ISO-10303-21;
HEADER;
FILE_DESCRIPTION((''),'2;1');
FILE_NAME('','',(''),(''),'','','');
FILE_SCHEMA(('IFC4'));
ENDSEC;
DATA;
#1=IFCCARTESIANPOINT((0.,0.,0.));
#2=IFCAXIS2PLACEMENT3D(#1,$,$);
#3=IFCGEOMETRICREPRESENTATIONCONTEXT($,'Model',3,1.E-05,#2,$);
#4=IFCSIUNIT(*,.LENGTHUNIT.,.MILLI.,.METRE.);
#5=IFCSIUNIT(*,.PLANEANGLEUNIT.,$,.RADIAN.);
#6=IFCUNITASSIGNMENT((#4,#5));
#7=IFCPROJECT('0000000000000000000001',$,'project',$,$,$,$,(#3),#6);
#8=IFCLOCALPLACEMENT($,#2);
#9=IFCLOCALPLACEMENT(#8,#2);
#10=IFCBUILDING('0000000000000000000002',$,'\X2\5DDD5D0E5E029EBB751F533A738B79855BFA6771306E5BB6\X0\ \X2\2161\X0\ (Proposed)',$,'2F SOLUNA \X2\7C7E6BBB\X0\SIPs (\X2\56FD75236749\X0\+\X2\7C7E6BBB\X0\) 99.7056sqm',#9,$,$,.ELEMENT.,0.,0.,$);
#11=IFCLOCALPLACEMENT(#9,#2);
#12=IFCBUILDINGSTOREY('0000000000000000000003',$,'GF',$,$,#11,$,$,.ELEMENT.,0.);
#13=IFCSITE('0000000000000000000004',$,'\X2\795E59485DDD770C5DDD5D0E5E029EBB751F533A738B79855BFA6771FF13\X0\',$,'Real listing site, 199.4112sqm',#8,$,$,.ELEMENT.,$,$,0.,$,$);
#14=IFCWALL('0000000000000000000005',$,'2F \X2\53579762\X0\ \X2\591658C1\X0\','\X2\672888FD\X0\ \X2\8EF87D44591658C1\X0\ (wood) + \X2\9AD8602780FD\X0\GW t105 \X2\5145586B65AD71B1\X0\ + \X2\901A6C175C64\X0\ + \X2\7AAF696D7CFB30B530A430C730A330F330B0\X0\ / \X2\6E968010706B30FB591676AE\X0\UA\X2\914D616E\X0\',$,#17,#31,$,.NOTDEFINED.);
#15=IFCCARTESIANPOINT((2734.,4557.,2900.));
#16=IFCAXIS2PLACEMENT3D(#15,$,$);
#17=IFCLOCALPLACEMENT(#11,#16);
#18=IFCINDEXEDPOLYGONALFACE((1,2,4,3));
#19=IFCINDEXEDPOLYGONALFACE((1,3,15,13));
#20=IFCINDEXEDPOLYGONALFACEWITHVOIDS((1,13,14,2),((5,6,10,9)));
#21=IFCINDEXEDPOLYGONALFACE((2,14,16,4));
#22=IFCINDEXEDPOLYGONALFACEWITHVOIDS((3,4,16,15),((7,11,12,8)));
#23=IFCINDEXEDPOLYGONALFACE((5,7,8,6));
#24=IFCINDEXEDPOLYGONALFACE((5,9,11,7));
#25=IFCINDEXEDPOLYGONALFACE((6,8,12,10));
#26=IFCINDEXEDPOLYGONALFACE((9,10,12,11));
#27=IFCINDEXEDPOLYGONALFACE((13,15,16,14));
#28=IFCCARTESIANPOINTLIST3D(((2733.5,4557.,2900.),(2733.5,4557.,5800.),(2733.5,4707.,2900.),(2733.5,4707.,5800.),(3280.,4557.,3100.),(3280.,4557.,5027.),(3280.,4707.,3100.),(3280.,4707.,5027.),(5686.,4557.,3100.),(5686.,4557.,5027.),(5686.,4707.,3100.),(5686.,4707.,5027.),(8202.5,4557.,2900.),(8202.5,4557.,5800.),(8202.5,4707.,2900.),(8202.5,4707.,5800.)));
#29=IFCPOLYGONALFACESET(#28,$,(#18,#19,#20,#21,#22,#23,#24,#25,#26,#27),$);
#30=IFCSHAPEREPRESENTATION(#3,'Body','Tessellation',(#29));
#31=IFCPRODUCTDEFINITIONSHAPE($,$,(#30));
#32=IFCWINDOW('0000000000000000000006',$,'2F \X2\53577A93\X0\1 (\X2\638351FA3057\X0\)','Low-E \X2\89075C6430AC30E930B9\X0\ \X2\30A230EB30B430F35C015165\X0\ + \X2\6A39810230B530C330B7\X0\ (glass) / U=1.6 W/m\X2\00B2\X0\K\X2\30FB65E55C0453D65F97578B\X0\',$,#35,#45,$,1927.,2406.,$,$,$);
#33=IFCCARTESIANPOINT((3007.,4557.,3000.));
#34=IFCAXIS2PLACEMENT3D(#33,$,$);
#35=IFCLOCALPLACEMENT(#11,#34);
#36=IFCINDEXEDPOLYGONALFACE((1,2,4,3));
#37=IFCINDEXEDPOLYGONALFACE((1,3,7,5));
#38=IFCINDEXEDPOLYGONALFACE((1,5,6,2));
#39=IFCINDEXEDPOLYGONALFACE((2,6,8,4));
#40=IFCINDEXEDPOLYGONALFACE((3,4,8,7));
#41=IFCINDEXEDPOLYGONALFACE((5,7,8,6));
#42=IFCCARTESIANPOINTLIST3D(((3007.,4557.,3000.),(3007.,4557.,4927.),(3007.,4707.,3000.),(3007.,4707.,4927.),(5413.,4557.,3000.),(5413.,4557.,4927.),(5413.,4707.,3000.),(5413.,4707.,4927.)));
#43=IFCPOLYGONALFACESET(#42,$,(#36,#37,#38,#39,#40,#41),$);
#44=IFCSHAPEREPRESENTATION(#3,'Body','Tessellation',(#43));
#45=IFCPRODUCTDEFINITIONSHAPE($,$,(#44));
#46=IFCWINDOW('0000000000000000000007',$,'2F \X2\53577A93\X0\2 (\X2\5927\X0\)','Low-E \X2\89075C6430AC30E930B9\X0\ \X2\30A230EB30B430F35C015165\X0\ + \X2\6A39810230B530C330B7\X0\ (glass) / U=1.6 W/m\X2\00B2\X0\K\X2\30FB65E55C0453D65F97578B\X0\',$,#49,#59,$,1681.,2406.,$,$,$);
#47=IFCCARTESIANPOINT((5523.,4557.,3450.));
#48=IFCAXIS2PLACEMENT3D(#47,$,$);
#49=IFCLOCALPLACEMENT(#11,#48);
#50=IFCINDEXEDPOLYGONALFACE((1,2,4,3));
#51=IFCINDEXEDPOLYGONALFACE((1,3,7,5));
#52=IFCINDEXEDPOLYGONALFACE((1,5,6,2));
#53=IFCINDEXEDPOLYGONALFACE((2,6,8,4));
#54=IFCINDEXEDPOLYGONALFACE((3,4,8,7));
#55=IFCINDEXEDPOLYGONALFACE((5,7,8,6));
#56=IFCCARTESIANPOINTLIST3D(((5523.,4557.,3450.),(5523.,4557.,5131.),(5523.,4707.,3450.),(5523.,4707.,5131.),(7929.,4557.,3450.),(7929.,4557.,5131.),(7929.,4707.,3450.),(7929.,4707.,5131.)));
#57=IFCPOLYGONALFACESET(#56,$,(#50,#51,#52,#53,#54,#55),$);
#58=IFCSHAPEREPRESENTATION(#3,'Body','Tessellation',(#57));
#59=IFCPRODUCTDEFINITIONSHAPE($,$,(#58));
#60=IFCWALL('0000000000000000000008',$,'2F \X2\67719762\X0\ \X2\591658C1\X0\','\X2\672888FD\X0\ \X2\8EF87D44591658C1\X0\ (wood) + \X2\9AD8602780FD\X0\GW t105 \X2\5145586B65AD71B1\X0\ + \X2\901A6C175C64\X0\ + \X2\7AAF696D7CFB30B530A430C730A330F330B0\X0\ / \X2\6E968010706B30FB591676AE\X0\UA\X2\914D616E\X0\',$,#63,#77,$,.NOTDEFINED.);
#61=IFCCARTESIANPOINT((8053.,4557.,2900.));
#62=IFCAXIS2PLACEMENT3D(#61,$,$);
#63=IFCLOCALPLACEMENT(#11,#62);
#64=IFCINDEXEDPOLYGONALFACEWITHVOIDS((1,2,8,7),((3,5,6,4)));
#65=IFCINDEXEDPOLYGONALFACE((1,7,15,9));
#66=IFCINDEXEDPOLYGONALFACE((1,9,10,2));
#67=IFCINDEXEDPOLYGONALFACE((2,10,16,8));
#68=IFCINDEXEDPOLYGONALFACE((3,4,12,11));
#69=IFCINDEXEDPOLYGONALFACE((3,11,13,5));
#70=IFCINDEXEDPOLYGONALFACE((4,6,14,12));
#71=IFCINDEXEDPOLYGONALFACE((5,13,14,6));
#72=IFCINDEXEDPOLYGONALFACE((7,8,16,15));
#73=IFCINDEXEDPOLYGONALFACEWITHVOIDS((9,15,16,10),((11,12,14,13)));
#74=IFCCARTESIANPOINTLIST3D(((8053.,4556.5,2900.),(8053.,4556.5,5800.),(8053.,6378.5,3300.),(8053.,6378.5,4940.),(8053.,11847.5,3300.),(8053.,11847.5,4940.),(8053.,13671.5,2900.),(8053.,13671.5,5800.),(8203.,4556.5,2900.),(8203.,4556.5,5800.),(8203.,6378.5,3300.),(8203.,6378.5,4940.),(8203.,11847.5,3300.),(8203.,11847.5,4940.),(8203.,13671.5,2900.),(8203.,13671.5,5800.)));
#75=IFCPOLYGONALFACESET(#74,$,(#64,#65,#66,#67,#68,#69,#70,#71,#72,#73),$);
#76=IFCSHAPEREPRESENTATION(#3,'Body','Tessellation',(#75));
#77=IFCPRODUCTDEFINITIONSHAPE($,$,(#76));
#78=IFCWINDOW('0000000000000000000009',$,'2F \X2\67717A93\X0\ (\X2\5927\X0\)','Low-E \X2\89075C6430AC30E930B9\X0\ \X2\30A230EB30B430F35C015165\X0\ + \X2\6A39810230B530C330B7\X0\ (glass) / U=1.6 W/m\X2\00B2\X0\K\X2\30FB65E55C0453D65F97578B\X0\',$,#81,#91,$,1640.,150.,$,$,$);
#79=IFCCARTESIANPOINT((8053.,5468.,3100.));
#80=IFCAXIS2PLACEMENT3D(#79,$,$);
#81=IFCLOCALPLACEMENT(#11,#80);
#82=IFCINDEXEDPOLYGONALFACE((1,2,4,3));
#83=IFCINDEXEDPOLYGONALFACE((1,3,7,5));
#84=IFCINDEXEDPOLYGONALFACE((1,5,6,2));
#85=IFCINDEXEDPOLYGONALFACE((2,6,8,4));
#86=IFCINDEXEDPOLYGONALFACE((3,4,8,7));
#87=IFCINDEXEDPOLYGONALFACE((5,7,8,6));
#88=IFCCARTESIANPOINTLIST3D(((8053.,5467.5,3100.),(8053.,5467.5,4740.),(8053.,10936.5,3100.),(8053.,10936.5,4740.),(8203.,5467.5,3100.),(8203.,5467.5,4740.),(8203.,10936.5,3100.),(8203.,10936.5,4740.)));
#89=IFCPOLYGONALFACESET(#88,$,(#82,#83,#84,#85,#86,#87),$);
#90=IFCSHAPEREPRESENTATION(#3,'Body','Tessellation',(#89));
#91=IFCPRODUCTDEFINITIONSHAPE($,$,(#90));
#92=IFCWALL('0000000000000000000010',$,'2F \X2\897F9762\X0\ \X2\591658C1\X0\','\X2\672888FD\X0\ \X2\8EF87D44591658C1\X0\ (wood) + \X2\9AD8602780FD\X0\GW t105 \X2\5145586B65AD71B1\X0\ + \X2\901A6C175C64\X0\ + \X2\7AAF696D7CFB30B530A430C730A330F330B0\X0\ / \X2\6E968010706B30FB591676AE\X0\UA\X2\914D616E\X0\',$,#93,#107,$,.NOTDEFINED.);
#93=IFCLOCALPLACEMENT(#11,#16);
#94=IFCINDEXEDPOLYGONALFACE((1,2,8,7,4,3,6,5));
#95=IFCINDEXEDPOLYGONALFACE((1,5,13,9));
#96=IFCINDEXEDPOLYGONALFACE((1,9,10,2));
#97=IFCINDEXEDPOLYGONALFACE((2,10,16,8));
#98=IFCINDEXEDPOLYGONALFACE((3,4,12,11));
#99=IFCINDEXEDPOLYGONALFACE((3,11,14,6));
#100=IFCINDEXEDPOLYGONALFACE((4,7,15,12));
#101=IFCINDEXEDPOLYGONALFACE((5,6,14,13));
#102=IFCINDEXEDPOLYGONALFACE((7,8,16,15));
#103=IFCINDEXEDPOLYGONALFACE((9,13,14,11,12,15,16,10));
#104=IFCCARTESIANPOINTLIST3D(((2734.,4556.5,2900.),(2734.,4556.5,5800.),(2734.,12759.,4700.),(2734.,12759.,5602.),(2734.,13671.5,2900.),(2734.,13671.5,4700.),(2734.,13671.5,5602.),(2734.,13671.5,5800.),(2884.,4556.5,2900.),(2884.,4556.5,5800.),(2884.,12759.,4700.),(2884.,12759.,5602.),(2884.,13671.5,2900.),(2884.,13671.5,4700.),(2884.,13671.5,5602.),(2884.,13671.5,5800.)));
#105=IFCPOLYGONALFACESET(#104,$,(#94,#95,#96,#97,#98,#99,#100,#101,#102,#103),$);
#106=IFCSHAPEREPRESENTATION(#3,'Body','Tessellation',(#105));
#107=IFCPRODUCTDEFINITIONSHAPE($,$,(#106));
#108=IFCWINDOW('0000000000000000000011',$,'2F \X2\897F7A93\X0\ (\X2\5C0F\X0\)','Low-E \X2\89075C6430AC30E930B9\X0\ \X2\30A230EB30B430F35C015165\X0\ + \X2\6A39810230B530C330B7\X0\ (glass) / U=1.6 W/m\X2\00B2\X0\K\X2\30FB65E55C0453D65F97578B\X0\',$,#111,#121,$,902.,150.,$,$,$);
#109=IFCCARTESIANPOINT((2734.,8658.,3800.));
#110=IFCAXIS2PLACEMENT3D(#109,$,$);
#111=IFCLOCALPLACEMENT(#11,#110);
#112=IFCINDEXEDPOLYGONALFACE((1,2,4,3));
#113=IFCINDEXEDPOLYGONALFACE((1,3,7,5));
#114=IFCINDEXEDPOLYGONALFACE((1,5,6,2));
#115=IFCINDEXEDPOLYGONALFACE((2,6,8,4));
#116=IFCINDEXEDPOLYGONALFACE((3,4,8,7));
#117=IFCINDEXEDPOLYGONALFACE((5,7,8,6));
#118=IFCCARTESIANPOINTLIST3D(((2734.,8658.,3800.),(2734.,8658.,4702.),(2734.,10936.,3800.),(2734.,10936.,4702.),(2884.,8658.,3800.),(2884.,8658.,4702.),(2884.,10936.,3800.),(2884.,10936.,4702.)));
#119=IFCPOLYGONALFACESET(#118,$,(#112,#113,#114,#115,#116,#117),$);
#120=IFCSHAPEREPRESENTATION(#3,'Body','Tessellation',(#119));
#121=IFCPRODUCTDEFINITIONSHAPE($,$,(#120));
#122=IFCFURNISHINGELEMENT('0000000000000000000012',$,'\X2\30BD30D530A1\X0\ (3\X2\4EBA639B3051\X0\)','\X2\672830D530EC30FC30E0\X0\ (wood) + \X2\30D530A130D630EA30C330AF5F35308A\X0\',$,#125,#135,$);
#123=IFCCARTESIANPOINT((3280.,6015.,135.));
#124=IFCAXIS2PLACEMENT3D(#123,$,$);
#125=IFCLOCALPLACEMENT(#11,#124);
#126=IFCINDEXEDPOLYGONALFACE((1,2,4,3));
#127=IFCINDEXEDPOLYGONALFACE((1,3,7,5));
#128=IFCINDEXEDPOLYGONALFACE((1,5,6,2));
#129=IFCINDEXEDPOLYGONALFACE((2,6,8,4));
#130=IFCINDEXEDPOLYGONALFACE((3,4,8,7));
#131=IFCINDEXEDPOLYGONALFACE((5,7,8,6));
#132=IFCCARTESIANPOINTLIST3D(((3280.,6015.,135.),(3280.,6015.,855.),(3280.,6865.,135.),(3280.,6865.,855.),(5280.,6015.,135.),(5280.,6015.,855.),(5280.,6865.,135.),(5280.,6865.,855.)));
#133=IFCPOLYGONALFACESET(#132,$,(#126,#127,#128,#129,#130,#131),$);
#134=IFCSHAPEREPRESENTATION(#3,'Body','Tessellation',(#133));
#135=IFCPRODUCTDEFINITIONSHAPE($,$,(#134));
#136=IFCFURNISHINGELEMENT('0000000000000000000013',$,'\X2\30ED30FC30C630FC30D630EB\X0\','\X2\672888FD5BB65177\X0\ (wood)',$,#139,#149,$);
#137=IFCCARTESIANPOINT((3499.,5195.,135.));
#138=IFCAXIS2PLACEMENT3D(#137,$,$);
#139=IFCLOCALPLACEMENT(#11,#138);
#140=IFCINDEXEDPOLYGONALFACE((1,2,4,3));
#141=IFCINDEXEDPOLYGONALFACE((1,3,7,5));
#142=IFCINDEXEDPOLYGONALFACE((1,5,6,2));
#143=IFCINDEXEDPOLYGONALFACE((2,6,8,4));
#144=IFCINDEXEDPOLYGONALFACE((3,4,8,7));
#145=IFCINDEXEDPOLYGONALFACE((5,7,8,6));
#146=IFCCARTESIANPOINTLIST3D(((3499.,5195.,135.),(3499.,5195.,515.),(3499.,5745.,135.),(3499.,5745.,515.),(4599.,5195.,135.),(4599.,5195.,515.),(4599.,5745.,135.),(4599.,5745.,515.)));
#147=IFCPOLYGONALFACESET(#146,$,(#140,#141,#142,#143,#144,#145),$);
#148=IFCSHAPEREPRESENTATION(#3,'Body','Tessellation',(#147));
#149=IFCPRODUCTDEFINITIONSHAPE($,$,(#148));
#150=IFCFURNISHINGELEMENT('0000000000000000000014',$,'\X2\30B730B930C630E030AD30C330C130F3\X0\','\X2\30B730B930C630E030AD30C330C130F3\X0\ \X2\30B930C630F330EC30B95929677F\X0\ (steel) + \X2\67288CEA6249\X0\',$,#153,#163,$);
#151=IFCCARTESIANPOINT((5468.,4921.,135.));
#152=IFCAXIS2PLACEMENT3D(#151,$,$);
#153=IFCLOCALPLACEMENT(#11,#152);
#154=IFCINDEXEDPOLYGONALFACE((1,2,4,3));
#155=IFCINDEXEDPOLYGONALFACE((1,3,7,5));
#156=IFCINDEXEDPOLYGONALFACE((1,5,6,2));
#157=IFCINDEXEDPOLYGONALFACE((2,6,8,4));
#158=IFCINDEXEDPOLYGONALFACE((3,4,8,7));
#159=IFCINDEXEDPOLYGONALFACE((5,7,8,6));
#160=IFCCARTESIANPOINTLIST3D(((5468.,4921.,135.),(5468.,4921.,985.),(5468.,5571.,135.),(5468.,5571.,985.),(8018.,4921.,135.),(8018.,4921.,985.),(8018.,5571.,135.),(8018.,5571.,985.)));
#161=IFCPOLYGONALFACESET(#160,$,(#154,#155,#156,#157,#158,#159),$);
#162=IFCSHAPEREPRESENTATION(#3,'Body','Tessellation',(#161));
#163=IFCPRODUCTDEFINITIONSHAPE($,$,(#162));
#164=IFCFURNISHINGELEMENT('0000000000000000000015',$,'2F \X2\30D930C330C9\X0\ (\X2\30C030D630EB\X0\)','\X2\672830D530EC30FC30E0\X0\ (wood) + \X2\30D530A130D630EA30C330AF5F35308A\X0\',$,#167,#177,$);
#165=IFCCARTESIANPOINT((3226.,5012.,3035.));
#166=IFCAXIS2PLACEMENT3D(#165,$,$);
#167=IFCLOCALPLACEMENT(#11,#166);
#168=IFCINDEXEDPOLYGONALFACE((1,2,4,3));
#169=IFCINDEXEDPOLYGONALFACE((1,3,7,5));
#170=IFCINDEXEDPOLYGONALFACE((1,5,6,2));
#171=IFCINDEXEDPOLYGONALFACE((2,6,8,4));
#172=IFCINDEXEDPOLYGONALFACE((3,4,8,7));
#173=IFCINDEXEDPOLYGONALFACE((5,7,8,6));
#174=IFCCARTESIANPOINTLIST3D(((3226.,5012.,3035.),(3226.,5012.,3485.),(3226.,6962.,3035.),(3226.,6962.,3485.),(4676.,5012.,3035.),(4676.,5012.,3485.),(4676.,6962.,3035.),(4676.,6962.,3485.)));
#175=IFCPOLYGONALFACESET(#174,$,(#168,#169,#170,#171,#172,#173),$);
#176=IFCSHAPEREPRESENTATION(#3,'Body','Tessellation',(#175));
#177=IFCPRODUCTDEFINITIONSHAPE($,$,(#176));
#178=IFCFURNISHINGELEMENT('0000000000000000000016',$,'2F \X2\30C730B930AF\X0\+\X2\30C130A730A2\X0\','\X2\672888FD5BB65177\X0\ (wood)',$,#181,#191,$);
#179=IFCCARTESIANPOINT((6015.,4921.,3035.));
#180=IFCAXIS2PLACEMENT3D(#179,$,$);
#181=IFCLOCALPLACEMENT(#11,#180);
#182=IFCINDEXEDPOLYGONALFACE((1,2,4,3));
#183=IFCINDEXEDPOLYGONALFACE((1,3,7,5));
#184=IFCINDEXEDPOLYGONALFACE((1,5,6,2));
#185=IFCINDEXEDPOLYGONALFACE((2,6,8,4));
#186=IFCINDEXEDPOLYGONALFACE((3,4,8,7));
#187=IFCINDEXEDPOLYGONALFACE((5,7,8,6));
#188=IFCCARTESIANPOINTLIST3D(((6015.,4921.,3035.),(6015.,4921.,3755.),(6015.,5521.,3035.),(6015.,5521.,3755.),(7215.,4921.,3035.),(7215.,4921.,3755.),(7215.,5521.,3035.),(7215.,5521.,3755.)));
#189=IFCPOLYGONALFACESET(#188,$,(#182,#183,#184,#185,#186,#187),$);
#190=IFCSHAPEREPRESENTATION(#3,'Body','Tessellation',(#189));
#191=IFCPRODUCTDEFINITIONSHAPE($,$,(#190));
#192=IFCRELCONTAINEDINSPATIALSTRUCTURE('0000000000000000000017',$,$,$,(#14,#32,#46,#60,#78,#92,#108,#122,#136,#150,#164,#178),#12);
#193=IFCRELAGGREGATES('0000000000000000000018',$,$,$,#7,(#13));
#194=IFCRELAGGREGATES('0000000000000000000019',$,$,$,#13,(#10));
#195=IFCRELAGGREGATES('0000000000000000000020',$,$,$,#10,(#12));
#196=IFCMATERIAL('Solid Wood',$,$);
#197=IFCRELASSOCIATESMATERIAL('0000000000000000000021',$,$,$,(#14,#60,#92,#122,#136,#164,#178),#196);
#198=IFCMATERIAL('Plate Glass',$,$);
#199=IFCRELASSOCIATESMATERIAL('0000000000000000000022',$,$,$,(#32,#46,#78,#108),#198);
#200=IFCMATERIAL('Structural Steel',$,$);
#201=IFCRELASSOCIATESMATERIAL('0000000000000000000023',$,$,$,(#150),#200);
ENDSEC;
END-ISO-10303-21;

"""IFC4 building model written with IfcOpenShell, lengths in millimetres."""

from ifc_helpers import new_model, si_unit, frame, frame_2d, origin, place, context, project, spatial, rectangle, extrude, material, element, fill, save


model = new_model("IFC4")

# Units and contexts
model_context = context("Model", 3, precision=1e-05, world=origin())
ifc_project = project(units=[si_unit("LENGTHUNIT", "METRE", prefix="MILLI"), si_unit("PLANEANGLEUNIT", "RADIAN")], contexts=[model_context])

# Site, building, storey
site_placement = place(None, origin())
site = spatial("IfcSite", under=ifc_project, at=site_placement, Name="神奈川県川崎市麻生区王禅寺東３", ObjectType="Real listing site, 199.4112sqm", CompositionType="ELEMENT", RefElevation=0.0)
building_placement = place(site_placement, origin())
building = spatial("IfcBuilding", under=site, at=building_placement, Name="川崎市麻生区王禅寺東の家 Ⅱ (Proposed)", ObjectType="2F SOLUNA 籾殻SIPs (国産杉+籾殻) 99.7056sqm", CompositionType="ELEMENT", ElevationOfRefHeight=0.0, ElevationOfTerrain=0.0)
storey_placement = place(building_placement, origin())
storey = spatial("IfcBuildingStorey", under=building, at=storey_placement, Name="GF", CompositionType="ELEMENT", Elevation=0.0)

# Shared definitions
ifc_material_1 = material(Name="Solid Wood")

# Wall, openings, windows
wall_1_placement = place(storey_placement, frame((2734.0, 4557.0, 2900.0)))
wall_1 = element("IfcWall", 1, at=wall_1_placement, inside=storey, material=ifc_material_1, Name="2F 南面 外壁", Description="木製 軸組外壁 (wood) + 高性能GW t105 充填断熱 + 通気層 + 窯業系サイディング / 準耐火・外皮UA配慮", PredefinedType="NOTDEFINED", context=model_context, shape_type="SweptSolid", body=[
    extrude(rectangle(XDim=5469.0, YDim=150.0, at=frame_2d((2734.0, 75.0))), frame((2734.0, 4557.0, 2900.0)), (0.0, 0.0, 1.0), 2900.0),
])
opening_1_placement = place(storey_placement, frame((3007.0, 4557.0, 3000.0)))
opening_1 = element("IfcOpeningElement", 2, at=opening_1_placement, cuts=wall_1, PredefinedType="NOTDEFINED", context=model_context, shape_type="SweptSolid", body=[
    extrude(rectangle(XDim=2406.0, YDim=150.0, at=frame_2d((1203.0, 75.0))), frame((3007.0, 4557.0, 3000.0)), (0.0, 0.0, 1.0), 1927.0),
])
opening_2_placement = place(storey_placement, frame((5523.0, 4557.0, 3450.0)))
opening_2 = element("IfcOpeningElement", 3, at=opening_2_placement, cuts=wall_1, PredefinedType="NOTDEFINED", context=model_context, shape_type="SweptSolid", body=[
    extrude(rectangle(XDim=2406.0, YDim=150.0, at=frame_2d((1203.0, 75.0))), frame((5523.0, 4557.0, 3450.0)), (0.0, 0.0, 1.0), 1681.0),
])
ifc_material_2 = material(Name="Plate Glass")
window_1_placement = place(storey_placement, frame((3007.0, 4557.0, 3000.0)))
window_1 = element("IfcWindow", 4, at=window_1_placement, inside=storey, material=ifc_material_2, Name="2F 南窓1 (掃出し)", Description="Low-E 複層ガラス アルゴン封入 + 樹脂サッシ (glass) / U=1.6 W/m²K・日射取得型", OverallHeight=1927.0, OverallWidth=2406.0, context=model_context, shape_type="SweptSolid", body=[
    extrude(rectangle(XDim=2406.0, YDim=150.0, at=frame_2d((1203.0, 75.0))), frame((3007.0, 4557.0, 3000.0)), (0.0, 0.0, 1.0), 1927.0),
])
fill(opening_1, window_1)
window_2_placement = place(storey_placement, frame((5523.0, 4557.0, 3450.0)))
window_2 = element("IfcWindow", 5, at=window_2_placement, inside=storey, material=ifc_material_2, Name="2F 南窓2 (大)", Description="Low-E 複層ガラス アルゴン封入 + 樹脂サッシ (glass) / U=1.6 W/m²K・日射取得型", OverallHeight=1681.0, OverallWidth=2406.0, context=model_context, shape_type="SweptSolid", body=[
    extrude(rectangle(XDim=2406.0, YDim=150.0, at=frame_2d((1203.0, 75.0))), frame((5523.0, 4557.0, 3450.0)), (0.0, 0.0, 1.0), 1681.0),
])
fill(opening_2, window_2)

# Walls, openings, windows
wall_2_placement = place(storey_placement, frame((8053.0, 4557.0, 2900.0)))
wall_2 = element("IfcWall", 6, at=wall_2_placement, inside=storey, material=ifc_material_1, Name="2F 東面 外壁", Description="木製 軸組外壁 (wood) + 高性能GW t105 充填断熱 + 通気層 + 窯業系サイディング / 準耐火・外皮UA配慮", PredefinedType="NOTDEFINED", context=model_context, shape_type="SweptSolid", body=[
    extrude(rectangle(XDim=150.0, YDim=9115.0, at=frame_2d((75.0, 4557.0))), frame((8053.0, 4557.0, 2900.0)), (0.0, 0.0, 1.0), 2900.0),
])
opening_3_placement = place(storey_placement, frame((8053.0, 5468.0, 3100.0)))
opening_3 = element("IfcOpeningElement", 7, at=opening_3_placement, cuts=wall_2, PredefinedType="NOTDEFINED", context=model_context, shape_type="SweptSolid", body=[
    extrude(rectangle(XDim=150.0, YDim=5469.0, at=frame_2d((75.0, 2734.0))), frame((8053.0, 5468.0, 3100.0)), (0.0, 0.0, 1.0), 1640.0),
])
window_3_placement = place(storey_placement, frame((8053.0, 5468.0, 3100.0)))
window_3 = element("IfcWindow", 8, at=window_3_placement, inside=storey, material=ifc_material_2, Name="2F 東窓 (大)", Description="Low-E 複層ガラス アルゴン封入 + 樹脂サッシ (glass) / U=1.6 W/m²K・日射取得型", OverallHeight=1640.0, OverallWidth=150.0, context=model_context, shape_type="SweptSolid", body=[
    extrude(rectangle(XDim=150.0, YDim=5469.0, at=frame_2d((75.0, 2734.0))), frame((8053.0, 5468.0, 3100.0)), (0.0, 0.0, 1.0), 1640.0),
])
fill(opening_3, window_3)
wall_3_placement = place(storey_placement, frame((2734.0, 4557.0, 2900.0)))
wall_3 = element("IfcWall", 9, at=wall_3_placement, inside=storey, material=ifc_material_1, Name="2F 西面 外壁", Description="木製 軸組外壁 (wood) + 高性能GW t105 充填断熱 + 通気層 + 窯業系サイディング / 準耐火・外皮UA配慮", PredefinedType="NOTDEFINED", context=model_context, shape_type="SweptSolid", body=[
    extrude(rectangle(XDim=150.0, YDim=9115.0, at=frame_2d((75.0, 4557.0))), frame((2734.0, 4557.0, 2900.0)), (0.0, 0.0, 1.0), 2900.0),
])
opening_4_placement = place(storey_placement, frame((2734.0, 8658.0, 3800.0)))
opening_4 = element("IfcOpeningElement", 10, at=opening_4_placement, cuts=wall_3, PredefinedType="NOTDEFINED", context=model_context, shape_type="SweptSolid", body=[
    extrude(rectangle(XDim=150.0, YDim=2278.0, at=frame_2d((75.0, 1139.0))), frame((2734.0, 8658.0, 3800.0)), (0.0, 0.0, 1.0), 902.0),
])
window_4_placement = place(storey_placement, frame((2734.0, 8658.0, 3800.0)))
window_4 = element("IfcWindow", 11, at=window_4_placement, inside=storey, material=ifc_material_2, Name="2F 西窓 (小)", Description="Low-E 複層ガラス アルゴン封入 + 樹脂サッシ (glass) / U=1.6 W/m²K・日射取得型", OverallHeight=902.0, OverallWidth=150.0, context=model_context, shape_type="SweptSolid", body=[
    extrude(rectangle(XDim=150.0, YDim=2278.0, at=frame_2d((75.0, 1139.0))), frame((2734.0, 8658.0, 3800.0)), (0.0, 0.0, 1.0), 902.0),
])
fill(opening_4, window_4)

# Shared definitions
ifc_material_3 = material(Name="Structural Steel")

# Furnishing elements
furnishing_1_placement = place(storey_placement, frame((3280.0, 6015.0, 135.0)))
element("IfcFurnishingElement", 12, at=furnishing_1_placement, inside=storey, material=ifc_material_1, Name="ソファ (3人掛け)", Description="木フレーム (wood) + ファブリック張り", context=model_context, shape_type="SweptSolid", body=[
    extrude(rectangle(XDim=2000.0, YDim=850.0, at=frame_2d((1000.0, 425.0))), frame((3280.0, 6015.0, 135.0)), (0.0, 0.0, 1.0), 720.0),
])
furnishing_2_placement = place(storey_placement, frame((3499.0, 5195.0, 135.0)))
element("IfcFurnishingElement", 13, at=furnishing_2_placement, inside=storey, material=ifc_material_1, Name="ローテーブル", Description="木製家具 (wood)", context=model_context, shape_type="SweptSolid", body=[
    extrude(rectangle(XDim=1100.0, YDim=550.0, at=frame_2d((550.0, 275.0))), frame((3499.0, 5195.0, 135.0)), (0.0, 0.0, 1.0), 380.0),
])
furnishing_3_placement = place(storey_placement, frame((5468.0, 4921.0, 135.0)))
element("IfcFurnishingElement", 14, at=furnishing_3_placement, inside=storey, material=ifc_material_3, Name="システムキッチン", Description="システムキッチン ステンレス天板 (steel) + 木質扉", context=model_context, shape_type="SweptSolid", body=[
    extrude(rectangle(XDim=2550.0, YDim=650.0, at=frame_2d((1275.0, 325.0))), frame((5468.0, 4921.0, 135.0)), (0.0, 0.0, 1.0), 850.0),
])
furnishing_4_placement = place(storey_placement, frame((3226.0, 5012.0, 3035.0)))
element("IfcFurnishingElement", 15, at=furnishing_4_placement, inside=storey, material=ifc_material_1, Name="2F ベッド (ダブル)", Description="木フレーム (wood) + ファブリック張り", context=model_context, shape_type="SweptSolid", body=[
    extrude(rectangle(XDim=1450.0, YDim=1950.0, at=frame_2d((725.0, 975.0))), frame((3226.0, 5012.0, 3035.0)), (0.0, 0.0, 1.0), 450.0),
])
furnishing_5_placement = place(storey_placement, frame((6015.0, 4921.0, 3035.0)))
element("IfcFurnishingElement", 16, at=furnishing_5_placement, inside=storey, material=ifc_material_1, Name="2F デスク+チェア", Description="木製家具 (wood)", context=model_context, shape_type="SweptSolid", body=[
    extrude(rectangle(XDim=1200.0, YDim=600.0, at=frame_2d((600.0, 300.0))), frame((6015.0, 4921.0, 3035.0)), (0.0, 0.0, 1.0), 720.0),
])

save(model, "model.ifc")
